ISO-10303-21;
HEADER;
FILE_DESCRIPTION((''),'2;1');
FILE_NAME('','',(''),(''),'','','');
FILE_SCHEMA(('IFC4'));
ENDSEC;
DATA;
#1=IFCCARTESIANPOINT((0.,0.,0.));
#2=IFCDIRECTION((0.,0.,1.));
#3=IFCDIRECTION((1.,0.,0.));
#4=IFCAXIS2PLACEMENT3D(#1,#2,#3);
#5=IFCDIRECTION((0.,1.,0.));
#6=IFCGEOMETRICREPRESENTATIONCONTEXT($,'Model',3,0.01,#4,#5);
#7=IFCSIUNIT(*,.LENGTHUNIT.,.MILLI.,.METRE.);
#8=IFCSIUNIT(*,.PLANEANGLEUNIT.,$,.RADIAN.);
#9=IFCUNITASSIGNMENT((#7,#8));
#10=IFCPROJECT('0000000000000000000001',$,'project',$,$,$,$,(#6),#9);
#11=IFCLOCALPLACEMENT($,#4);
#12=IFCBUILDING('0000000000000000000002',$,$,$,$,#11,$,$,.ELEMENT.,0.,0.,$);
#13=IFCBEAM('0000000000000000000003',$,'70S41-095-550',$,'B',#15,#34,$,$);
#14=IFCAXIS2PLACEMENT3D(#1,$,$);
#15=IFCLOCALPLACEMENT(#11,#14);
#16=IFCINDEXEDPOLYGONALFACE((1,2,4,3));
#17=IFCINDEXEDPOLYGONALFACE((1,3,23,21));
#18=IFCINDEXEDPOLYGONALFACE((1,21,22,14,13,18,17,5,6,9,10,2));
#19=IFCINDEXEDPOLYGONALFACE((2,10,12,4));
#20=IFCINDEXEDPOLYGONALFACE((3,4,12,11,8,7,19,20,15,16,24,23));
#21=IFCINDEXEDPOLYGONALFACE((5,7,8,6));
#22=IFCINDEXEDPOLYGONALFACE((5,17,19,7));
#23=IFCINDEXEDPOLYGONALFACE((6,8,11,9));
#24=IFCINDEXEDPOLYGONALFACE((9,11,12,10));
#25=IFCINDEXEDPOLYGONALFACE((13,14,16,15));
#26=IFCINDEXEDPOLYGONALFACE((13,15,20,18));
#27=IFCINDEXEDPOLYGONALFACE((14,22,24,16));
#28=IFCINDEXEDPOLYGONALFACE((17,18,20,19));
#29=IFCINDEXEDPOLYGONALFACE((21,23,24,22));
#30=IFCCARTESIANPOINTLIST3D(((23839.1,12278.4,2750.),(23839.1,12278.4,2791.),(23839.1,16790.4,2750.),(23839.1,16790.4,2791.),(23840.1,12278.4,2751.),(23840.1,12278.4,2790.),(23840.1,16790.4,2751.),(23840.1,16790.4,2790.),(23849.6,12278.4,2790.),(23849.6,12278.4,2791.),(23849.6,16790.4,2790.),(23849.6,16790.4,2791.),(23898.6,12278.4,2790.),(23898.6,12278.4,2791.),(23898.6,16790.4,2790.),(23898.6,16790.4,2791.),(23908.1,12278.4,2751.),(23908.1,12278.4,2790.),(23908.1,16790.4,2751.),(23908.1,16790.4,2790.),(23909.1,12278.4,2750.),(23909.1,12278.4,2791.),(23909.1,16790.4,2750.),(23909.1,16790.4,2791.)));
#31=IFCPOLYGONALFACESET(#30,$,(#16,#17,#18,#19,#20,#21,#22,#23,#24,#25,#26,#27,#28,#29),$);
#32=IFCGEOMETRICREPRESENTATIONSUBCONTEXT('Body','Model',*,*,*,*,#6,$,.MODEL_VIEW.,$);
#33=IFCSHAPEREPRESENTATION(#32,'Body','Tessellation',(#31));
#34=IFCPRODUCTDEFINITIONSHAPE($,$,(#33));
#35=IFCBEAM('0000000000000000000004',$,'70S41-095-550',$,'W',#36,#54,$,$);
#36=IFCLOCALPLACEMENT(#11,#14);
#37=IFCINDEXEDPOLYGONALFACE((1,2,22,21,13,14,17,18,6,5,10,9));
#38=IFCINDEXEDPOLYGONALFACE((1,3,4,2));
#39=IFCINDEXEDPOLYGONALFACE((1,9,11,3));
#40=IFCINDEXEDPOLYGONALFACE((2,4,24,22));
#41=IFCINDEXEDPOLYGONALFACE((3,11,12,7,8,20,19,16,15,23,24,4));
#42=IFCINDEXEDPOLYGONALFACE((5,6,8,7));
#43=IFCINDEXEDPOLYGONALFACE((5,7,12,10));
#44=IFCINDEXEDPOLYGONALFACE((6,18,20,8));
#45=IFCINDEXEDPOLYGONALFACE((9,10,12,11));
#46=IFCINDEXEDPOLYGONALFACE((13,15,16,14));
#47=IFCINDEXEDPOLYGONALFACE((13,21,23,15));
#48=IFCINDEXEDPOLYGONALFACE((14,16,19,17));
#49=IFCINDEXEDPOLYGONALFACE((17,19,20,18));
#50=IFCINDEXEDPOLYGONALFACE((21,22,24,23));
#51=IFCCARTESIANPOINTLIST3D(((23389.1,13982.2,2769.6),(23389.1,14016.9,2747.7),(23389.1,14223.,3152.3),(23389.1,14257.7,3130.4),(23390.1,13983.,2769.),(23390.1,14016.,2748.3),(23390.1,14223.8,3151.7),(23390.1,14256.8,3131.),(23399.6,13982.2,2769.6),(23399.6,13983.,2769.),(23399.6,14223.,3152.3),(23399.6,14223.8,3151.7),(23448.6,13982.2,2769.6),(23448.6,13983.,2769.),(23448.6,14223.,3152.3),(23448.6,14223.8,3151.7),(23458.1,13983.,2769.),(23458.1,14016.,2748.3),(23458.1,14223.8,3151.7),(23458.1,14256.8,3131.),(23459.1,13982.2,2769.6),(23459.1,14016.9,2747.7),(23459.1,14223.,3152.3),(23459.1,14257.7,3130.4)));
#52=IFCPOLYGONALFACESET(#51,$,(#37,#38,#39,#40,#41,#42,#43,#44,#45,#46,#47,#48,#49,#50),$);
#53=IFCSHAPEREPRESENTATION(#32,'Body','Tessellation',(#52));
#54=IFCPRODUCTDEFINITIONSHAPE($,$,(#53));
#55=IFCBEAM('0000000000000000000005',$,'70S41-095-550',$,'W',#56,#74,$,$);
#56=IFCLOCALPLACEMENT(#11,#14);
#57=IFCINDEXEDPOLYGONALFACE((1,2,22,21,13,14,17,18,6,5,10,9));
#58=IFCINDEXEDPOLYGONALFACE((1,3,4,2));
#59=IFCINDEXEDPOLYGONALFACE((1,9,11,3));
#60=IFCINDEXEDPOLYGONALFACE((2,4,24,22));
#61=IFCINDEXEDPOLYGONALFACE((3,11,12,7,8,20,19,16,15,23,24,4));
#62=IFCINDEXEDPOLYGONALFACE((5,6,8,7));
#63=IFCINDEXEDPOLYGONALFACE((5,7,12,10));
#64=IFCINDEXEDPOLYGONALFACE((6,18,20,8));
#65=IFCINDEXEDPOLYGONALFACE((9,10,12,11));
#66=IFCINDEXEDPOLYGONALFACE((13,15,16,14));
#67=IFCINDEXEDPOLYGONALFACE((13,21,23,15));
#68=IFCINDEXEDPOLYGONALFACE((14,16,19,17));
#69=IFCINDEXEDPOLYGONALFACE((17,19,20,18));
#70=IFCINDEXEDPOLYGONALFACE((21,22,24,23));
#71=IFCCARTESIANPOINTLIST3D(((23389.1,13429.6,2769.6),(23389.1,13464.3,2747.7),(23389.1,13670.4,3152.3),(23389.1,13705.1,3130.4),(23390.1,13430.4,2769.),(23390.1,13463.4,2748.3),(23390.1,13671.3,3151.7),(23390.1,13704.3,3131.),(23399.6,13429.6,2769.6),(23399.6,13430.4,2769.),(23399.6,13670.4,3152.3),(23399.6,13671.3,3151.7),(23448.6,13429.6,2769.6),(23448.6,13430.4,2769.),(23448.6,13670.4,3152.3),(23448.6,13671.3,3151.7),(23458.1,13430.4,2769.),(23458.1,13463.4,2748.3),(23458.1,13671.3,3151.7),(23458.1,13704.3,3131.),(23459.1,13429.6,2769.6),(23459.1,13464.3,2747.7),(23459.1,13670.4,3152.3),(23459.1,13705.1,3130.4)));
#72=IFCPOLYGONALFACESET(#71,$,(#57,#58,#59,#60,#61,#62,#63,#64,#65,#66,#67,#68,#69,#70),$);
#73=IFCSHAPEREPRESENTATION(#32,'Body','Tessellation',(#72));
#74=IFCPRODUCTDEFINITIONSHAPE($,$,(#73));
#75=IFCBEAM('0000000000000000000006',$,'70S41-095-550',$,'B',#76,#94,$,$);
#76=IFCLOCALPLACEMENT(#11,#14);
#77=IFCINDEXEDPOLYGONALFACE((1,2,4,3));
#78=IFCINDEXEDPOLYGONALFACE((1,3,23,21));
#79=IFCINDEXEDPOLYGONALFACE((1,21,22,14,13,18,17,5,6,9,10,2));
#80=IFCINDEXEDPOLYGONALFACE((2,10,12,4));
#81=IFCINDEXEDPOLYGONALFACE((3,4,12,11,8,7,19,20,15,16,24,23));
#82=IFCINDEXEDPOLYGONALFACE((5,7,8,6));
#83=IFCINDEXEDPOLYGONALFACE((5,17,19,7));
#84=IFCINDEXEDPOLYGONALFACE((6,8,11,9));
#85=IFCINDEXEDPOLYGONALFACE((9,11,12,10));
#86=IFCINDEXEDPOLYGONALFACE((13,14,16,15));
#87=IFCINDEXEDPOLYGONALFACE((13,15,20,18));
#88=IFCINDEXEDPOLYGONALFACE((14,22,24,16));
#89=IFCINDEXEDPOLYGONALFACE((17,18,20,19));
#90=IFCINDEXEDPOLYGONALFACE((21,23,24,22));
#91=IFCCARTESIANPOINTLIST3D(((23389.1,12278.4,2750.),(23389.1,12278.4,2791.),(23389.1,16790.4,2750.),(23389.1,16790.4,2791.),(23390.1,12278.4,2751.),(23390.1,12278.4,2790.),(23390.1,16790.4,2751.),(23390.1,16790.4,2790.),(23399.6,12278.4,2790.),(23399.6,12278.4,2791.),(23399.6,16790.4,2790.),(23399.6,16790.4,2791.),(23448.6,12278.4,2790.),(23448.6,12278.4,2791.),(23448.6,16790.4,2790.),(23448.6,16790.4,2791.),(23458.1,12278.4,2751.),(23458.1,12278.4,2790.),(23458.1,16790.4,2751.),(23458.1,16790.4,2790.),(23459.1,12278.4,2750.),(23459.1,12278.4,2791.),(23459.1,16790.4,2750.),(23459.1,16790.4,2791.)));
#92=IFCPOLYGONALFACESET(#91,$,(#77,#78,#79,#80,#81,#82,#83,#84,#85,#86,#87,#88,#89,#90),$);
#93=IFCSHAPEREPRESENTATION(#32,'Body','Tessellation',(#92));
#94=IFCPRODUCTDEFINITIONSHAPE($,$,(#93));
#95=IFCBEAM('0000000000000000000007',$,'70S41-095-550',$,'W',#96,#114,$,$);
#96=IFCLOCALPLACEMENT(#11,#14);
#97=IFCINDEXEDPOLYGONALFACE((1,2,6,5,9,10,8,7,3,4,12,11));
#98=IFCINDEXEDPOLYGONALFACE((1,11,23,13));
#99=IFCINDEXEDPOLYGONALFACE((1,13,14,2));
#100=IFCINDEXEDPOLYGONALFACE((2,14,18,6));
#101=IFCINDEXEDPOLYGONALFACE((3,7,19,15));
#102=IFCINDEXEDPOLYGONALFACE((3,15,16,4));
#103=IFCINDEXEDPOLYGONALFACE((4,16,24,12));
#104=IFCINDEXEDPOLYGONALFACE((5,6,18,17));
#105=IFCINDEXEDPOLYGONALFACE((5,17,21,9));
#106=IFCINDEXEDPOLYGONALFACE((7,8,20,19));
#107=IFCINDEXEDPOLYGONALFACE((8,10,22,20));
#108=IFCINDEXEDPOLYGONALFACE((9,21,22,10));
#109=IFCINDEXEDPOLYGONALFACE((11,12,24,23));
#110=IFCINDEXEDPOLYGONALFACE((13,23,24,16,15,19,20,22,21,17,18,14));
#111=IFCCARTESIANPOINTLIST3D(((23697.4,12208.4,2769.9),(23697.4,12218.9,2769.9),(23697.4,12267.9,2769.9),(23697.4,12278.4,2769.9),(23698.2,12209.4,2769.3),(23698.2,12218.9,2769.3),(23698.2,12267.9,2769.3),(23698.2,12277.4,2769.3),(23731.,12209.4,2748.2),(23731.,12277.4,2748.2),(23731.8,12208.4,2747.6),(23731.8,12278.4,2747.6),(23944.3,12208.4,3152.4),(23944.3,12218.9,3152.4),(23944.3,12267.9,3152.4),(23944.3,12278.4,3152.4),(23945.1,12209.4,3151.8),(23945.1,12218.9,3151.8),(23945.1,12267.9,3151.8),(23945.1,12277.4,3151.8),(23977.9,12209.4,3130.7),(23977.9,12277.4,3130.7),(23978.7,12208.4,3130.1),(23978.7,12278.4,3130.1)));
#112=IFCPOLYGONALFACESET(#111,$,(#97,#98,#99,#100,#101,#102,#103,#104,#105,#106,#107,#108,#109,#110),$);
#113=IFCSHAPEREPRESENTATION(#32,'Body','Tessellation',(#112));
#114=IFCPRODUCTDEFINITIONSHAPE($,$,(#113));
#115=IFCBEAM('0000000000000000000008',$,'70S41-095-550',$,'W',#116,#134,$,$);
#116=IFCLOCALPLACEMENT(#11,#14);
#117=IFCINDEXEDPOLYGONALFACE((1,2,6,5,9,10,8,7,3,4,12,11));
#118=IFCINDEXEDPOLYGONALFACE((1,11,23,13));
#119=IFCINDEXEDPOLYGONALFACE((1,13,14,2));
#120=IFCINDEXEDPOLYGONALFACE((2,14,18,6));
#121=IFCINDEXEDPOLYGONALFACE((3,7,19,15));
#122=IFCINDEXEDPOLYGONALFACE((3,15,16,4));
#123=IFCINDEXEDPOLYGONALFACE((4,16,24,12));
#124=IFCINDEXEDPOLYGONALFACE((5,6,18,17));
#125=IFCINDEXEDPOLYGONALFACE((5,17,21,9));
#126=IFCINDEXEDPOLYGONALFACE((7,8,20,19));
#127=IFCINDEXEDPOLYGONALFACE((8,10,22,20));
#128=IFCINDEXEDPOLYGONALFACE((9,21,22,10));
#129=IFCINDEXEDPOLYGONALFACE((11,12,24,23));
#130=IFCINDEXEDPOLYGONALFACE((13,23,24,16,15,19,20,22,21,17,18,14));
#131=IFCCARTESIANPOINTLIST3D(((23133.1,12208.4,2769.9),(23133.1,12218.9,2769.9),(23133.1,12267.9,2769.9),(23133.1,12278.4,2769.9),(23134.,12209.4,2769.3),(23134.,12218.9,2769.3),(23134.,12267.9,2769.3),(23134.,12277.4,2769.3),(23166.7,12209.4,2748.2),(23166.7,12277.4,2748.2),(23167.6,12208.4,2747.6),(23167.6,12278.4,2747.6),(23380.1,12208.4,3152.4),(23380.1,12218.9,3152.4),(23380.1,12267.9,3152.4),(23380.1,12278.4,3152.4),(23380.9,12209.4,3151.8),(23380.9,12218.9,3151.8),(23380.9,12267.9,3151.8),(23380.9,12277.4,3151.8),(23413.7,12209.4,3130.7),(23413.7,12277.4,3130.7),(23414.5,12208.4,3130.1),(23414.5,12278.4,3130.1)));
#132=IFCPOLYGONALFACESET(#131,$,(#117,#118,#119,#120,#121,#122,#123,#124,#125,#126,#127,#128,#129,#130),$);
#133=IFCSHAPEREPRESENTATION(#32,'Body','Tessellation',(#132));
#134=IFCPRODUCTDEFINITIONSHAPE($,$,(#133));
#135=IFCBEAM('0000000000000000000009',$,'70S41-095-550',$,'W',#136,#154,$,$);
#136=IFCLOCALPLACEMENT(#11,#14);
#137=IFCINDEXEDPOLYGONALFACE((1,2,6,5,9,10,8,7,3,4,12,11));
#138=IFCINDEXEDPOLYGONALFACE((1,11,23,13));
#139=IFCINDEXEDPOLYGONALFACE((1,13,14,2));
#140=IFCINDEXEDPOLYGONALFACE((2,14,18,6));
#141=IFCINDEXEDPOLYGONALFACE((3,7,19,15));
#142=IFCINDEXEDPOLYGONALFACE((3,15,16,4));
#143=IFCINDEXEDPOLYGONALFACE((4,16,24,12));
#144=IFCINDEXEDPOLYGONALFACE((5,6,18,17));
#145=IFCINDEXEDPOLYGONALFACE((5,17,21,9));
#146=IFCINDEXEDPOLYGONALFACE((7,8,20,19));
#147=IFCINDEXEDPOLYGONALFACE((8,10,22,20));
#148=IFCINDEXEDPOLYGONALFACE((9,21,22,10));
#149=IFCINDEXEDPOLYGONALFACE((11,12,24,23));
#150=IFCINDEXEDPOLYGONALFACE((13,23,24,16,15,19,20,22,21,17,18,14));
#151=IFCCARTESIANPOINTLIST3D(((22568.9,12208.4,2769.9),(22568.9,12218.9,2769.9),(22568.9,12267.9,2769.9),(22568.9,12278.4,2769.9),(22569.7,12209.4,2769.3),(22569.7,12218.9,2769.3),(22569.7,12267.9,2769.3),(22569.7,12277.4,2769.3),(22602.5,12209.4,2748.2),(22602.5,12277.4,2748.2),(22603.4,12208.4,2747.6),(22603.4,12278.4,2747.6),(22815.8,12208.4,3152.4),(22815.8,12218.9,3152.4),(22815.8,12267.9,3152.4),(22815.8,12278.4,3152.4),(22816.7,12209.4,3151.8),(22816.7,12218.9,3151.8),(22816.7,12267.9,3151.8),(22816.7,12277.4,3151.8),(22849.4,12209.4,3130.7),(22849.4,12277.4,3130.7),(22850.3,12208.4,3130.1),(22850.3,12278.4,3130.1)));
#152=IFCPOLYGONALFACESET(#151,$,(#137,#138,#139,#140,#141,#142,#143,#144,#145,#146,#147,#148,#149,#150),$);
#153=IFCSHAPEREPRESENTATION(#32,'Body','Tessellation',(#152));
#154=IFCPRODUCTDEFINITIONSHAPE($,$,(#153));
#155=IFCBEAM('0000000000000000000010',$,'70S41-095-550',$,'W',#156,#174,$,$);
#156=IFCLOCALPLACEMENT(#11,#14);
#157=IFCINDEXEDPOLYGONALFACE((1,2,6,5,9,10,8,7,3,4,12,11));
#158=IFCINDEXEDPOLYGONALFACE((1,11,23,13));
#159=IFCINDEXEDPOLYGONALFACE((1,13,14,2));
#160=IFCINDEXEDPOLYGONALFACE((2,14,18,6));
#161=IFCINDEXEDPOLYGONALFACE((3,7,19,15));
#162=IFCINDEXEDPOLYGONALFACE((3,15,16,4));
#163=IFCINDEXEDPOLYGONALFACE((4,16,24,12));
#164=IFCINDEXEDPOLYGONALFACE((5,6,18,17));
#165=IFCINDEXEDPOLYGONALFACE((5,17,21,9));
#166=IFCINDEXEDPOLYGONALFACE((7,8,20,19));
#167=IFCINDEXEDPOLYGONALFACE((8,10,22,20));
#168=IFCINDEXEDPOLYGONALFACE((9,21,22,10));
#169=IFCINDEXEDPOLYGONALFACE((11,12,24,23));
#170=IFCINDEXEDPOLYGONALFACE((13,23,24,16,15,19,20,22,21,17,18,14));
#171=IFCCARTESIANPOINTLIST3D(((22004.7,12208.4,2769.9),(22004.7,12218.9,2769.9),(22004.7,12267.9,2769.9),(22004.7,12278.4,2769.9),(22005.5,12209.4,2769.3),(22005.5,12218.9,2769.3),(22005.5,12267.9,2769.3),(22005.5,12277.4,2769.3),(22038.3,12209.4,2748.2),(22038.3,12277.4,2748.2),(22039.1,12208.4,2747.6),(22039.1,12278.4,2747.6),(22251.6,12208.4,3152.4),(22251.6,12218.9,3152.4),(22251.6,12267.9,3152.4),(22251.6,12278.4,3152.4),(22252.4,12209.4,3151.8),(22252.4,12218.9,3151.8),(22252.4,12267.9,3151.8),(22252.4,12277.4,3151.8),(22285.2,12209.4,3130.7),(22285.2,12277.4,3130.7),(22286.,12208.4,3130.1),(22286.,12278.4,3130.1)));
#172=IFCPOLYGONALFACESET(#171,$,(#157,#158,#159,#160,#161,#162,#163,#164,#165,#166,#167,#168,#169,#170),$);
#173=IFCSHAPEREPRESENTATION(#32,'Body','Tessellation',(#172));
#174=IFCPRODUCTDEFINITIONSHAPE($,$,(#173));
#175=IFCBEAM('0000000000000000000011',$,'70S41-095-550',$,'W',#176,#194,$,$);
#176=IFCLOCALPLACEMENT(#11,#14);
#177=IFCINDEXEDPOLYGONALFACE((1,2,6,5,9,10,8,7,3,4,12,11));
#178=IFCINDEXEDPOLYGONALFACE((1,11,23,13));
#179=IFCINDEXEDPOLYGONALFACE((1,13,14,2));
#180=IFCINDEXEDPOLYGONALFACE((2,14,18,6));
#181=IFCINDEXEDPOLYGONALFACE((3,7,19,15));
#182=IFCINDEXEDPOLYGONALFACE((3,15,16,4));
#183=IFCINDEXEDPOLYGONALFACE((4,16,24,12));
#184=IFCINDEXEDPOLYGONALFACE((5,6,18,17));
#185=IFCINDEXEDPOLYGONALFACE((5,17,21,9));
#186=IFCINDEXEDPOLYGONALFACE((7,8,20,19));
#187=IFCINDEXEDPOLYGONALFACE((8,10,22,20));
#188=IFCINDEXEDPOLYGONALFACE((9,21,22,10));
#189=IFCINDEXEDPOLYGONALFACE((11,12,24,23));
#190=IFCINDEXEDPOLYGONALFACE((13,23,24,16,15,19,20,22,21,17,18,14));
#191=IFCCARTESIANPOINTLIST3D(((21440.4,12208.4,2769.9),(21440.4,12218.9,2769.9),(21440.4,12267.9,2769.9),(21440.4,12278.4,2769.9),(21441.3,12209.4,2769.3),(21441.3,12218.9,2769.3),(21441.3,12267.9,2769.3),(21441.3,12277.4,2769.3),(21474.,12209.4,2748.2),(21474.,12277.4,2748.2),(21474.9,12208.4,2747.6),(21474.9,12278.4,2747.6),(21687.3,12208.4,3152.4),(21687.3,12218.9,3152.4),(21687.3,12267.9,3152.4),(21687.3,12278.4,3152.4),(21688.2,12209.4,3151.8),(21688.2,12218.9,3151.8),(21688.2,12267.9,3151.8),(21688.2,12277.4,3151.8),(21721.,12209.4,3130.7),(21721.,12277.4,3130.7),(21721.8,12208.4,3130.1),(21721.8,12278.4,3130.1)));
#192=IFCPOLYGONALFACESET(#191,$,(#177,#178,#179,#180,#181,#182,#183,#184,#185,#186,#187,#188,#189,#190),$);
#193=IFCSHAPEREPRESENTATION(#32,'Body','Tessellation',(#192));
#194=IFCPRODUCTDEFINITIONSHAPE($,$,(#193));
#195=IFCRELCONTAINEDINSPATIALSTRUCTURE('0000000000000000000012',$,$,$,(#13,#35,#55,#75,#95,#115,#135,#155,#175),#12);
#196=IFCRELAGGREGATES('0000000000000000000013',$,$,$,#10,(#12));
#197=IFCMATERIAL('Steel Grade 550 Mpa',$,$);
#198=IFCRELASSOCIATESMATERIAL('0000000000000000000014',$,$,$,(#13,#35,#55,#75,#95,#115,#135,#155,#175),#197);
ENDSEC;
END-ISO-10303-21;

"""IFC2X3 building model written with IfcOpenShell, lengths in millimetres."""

from ifc_helpers import new_model, si_unit, direction, frame, origin, origin_with_axes, origin_2d_with_axis, place, context, subcontext, project, spatial, c_section, extrude, source, transform, mapped, material, element, save


model = new_model("IFC2X3")

# Units and contexts
model_context = context("Model", 3, precision=0.01, world=origin_with_axes(), true_north=direction((0.0, 1.0, 0.0)))
body_context = subcontext(model_context, "Body", "Model", "MODEL_VIEW")
ifc_project = project(units=[si_unit("LENGTHUNIT", "METRE", prefix="MILLI"), si_unit("PLANEANGLEUNIT", "RADIAN")], contexts=[model_context])

# Building
building_placement = place(None, origin_with_axes())
building = spatial("IfcBuilding", under=ifc_project, at=building_placement, CompositionType="ELEMENT", ElevationOfRefHeight=0.0, ElevationOfTerrain=0.0)

# Beams
ifc_material = material(Name="Steel Grade 550 Mpa")
shared_shape_1 = source(origin(), body_context, "Body", "SweptSolid", [
    extrude(c_section(Depth=70.0, Width=41.0, WallThickness=1.0, Girth=10.5, at=origin_2d_with_axis()), origin_with_axes(), (0.0, 0.0, 1.0), 4512.0),
])
beam_1_placement = place(None, frame((23874.1, 12278.4, 2770.5), z_axis=(0.0, 1.0, 0.0), x_axis=(0.0, 0.0, 1.0)))
element("IfcBeam", 1, at=beam_1_placement, inside=building, material=ifc_material, Name="70S41-095-550", ObjectType="B", context=body_context, shape_type="MappedRepresentation", body=[
    mapped(shared_shape_1, transform((0.0, 0.0, 0.0), scale=1.0)),
])
shared_shape_2 = source(origin(), body_context, "Body", "SweptSolid", [
    extrude(c_section(Depth=70.0, Width=41.0, WallThickness=1.0, Girth=10.5, at=origin_2d_with_axis()), origin_with_axes(), (0.0, 0.0, 1.0), 452.2),
])
beam_2_placement = place(None, frame((23424.1, 13999.5, 2758.7), z_axis=(0.0, 0.532581, 0.846379), x_axis=(0.0, -0.846379, 0.532581)))
element("IfcBeam", 2, at=beam_2_placement, inside=building, material=ifc_material, Name="70S41-095-550", ObjectType="W", context=body_context, shape_type="MappedRepresentation", body=[
    mapped(shared_shape_2, transform((0.0, 0.0, 0.0), scale=1.0)),
])
shared_shape_3 = source(origin(), body_context, "Body", "SweptSolid", [
    extrude(c_section(Depth=70.0, Width=41.0, WallThickness=1.0, Girth=10.5, at=origin_2d_with_axis()), origin_with_axes(), (0.0, 0.0, 1.0), 452.2),
])
beam_3_placement = place(None, frame((23424.1, 13446.9, 2758.7), z_axis=(0.0, 0.532581, 0.846379), x_axis=(0.0, -0.846379, 0.532581)))
element("IfcBeam", 3, at=beam_3_placement, inside=building, material=ifc_material, Name="70S41-095-550", ObjectType="W", context=body_context, shape_type="MappedRepresentation", body=[
    mapped(shared_shape_3, transform((0.0, 0.0, 0.0), scale=1.0)),
])
shared_shape_4 = source(origin(), body_context, "Body", "SweptSolid", [
    extrude(c_section(Depth=70.0, Width=41.0, WallThickness=1.0, Girth=10.5, at=origin_2d_with_axis()), origin_with_axes(), (0.0, 0.0, 1.0), 4512.0),
])
beam_4_placement = place(None, frame((23424.1, 12278.4, 2770.5), z_axis=(0.0, 1.0, 0.0), x_axis=(0.0, 0.0, 1.0)))
element("IfcBeam", 4, at=beam_4_placement, inside=building, material=ifc_material, Name="70S41-095-550", ObjectType="B", context=body_context, shape_type="MappedRepresentation", body=[
    mapped(shared_shape_4, transform((0.0, 0.0, 0.0), scale=1.0)),
])
shared_shape_5 = source(origin(), body_context, "Body", "SweptSolid", [
    extrude(c_section(Depth=70.0, Width=41.0, WallThickness=1.0, Girth=10.5, at=origin_2d_with_axis()), origin_with_axes(), (0.0, 0.0, 1.0), 455.3),
])
beam_5_placement = place(None, frame((23714.6, 12243.4, 2758.7), z_axis=(0.54232, 0.0, 0.840172), x_axis=(-0.840172, 0.0, 0.54232)))
element("IfcBeam", 5, at=beam_5_placement, inside=building, material=ifc_material, Name="70S41-095-550", ObjectType="W", context=body_context, shape_type="MappedRepresentation", body=[
    mapped(shared_shape_5, transform((0.0, 0.0, 0.0), scale=1.0)),
])
shared_shape_6 = source(origin(), body_context, "Body", "SweptSolid", [
    extrude(c_section(Depth=70.0, Width=41.0, WallThickness=1.0, Girth=10.5, at=origin_2d_with_axis()), origin_with_axes(), (0.0, 0.0, 1.0), 455.3),
])
beam_6_placement = place(None, frame((23150.4, 12243.4, 2758.7), z_axis=(0.54232, 0.0, 0.840172), x_axis=(-0.840172, 0.0, 0.54232)))
element("IfcBeam", 6, at=beam_6_placement, inside=building, material=ifc_material, Name="70S41-095-550", ObjectType="W", context=body_context, shape_type="MappedRepresentation", body=[
    mapped(shared_shape_6, transform((0.0, 0.0, 0.0), scale=1.0)),
])
shared_shape_7 = source(origin(), body_context, "Body", "SweptSolid", [
    extrude(c_section(Depth=70.0, Width=41.0, WallThickness=1.0, Girth=10.5, at=origin_2d_with_axis()), origin_with_axes(), (0.0, 0.0, 1.0), 455.3),
])
beam_7_placement = place(None, frame((22586.1, 12243.4, 2758.7), z_axis=(0.54232, 0.0, 0.840172), x_axis=(-0.840172, 0.0, 0.54232)))
element("IfcBeam", 7, at=beam_7_placement, inside=building, material=ifc_material, Name="70S41-095-550", ObjectType="W", context=body_context, shape_type="MappedRepresentation", body=[
    mapped(shared_shape_7, transform((0.0, 0.0, 0.0), scale=1.0)),
])
shared_shape_8 = source(origin(), body_context, "Body", "SweptSolid", [
    extrude(c_section(Depth=70.0, Width=41.0, WallThickness=1.0, Girth=10.5, at=origin_2d_with_axis()), origin_with_axes(), (0.0, 0.0, 1.0), 455.3),
])
beam_8_placement = place(None, frame((22021.9, 12243.4, 2758.7), z_axis=(0.54232, 0.0, 0.840172), x_axis=(-0.840172, 0.0, 0.54232)))
element("IfcBeam", 8, at=beam_8_placement, inside=building, material=ifc_material, Name="70S41-095-550", ObjectType="W", context=body_context, shape_type="MappedRepresentation", body=[
    mapped(shared_shape_8, transform((0.0, 0.0, 0.0), scale=1.0)),
])
shared_shape_9 = source(origin(), body_context, "Body", "SweptSolid", [
    extrude(c_section(Depth=70.0, Width=41.0, WallThickness=1.0, Girth=10.5, at=origin_2d_with_axis()), origin_with_axes(), (0.0, 0.0, 1.0), 455.3),
])
beam_9_placement = place(None, frame((21457.7, 12243.4, 2758.7), z_axis=(0.54232, 0.0, 0.840172), x_axis=(-0.840172, 0.0, 0.54232)))
element("IfcBeam", 9, at=beam_9_placement, inside=building, material=ifc_material, Name="70S41-095-550", ObjectType="W", context=body_context, shape_type="MappedRepresentation", body=[
    mapped(shared_shape_9, transform((0.0, 0.0, 0.0), scale=1.0)),
])

save(model, "model.ifc")
